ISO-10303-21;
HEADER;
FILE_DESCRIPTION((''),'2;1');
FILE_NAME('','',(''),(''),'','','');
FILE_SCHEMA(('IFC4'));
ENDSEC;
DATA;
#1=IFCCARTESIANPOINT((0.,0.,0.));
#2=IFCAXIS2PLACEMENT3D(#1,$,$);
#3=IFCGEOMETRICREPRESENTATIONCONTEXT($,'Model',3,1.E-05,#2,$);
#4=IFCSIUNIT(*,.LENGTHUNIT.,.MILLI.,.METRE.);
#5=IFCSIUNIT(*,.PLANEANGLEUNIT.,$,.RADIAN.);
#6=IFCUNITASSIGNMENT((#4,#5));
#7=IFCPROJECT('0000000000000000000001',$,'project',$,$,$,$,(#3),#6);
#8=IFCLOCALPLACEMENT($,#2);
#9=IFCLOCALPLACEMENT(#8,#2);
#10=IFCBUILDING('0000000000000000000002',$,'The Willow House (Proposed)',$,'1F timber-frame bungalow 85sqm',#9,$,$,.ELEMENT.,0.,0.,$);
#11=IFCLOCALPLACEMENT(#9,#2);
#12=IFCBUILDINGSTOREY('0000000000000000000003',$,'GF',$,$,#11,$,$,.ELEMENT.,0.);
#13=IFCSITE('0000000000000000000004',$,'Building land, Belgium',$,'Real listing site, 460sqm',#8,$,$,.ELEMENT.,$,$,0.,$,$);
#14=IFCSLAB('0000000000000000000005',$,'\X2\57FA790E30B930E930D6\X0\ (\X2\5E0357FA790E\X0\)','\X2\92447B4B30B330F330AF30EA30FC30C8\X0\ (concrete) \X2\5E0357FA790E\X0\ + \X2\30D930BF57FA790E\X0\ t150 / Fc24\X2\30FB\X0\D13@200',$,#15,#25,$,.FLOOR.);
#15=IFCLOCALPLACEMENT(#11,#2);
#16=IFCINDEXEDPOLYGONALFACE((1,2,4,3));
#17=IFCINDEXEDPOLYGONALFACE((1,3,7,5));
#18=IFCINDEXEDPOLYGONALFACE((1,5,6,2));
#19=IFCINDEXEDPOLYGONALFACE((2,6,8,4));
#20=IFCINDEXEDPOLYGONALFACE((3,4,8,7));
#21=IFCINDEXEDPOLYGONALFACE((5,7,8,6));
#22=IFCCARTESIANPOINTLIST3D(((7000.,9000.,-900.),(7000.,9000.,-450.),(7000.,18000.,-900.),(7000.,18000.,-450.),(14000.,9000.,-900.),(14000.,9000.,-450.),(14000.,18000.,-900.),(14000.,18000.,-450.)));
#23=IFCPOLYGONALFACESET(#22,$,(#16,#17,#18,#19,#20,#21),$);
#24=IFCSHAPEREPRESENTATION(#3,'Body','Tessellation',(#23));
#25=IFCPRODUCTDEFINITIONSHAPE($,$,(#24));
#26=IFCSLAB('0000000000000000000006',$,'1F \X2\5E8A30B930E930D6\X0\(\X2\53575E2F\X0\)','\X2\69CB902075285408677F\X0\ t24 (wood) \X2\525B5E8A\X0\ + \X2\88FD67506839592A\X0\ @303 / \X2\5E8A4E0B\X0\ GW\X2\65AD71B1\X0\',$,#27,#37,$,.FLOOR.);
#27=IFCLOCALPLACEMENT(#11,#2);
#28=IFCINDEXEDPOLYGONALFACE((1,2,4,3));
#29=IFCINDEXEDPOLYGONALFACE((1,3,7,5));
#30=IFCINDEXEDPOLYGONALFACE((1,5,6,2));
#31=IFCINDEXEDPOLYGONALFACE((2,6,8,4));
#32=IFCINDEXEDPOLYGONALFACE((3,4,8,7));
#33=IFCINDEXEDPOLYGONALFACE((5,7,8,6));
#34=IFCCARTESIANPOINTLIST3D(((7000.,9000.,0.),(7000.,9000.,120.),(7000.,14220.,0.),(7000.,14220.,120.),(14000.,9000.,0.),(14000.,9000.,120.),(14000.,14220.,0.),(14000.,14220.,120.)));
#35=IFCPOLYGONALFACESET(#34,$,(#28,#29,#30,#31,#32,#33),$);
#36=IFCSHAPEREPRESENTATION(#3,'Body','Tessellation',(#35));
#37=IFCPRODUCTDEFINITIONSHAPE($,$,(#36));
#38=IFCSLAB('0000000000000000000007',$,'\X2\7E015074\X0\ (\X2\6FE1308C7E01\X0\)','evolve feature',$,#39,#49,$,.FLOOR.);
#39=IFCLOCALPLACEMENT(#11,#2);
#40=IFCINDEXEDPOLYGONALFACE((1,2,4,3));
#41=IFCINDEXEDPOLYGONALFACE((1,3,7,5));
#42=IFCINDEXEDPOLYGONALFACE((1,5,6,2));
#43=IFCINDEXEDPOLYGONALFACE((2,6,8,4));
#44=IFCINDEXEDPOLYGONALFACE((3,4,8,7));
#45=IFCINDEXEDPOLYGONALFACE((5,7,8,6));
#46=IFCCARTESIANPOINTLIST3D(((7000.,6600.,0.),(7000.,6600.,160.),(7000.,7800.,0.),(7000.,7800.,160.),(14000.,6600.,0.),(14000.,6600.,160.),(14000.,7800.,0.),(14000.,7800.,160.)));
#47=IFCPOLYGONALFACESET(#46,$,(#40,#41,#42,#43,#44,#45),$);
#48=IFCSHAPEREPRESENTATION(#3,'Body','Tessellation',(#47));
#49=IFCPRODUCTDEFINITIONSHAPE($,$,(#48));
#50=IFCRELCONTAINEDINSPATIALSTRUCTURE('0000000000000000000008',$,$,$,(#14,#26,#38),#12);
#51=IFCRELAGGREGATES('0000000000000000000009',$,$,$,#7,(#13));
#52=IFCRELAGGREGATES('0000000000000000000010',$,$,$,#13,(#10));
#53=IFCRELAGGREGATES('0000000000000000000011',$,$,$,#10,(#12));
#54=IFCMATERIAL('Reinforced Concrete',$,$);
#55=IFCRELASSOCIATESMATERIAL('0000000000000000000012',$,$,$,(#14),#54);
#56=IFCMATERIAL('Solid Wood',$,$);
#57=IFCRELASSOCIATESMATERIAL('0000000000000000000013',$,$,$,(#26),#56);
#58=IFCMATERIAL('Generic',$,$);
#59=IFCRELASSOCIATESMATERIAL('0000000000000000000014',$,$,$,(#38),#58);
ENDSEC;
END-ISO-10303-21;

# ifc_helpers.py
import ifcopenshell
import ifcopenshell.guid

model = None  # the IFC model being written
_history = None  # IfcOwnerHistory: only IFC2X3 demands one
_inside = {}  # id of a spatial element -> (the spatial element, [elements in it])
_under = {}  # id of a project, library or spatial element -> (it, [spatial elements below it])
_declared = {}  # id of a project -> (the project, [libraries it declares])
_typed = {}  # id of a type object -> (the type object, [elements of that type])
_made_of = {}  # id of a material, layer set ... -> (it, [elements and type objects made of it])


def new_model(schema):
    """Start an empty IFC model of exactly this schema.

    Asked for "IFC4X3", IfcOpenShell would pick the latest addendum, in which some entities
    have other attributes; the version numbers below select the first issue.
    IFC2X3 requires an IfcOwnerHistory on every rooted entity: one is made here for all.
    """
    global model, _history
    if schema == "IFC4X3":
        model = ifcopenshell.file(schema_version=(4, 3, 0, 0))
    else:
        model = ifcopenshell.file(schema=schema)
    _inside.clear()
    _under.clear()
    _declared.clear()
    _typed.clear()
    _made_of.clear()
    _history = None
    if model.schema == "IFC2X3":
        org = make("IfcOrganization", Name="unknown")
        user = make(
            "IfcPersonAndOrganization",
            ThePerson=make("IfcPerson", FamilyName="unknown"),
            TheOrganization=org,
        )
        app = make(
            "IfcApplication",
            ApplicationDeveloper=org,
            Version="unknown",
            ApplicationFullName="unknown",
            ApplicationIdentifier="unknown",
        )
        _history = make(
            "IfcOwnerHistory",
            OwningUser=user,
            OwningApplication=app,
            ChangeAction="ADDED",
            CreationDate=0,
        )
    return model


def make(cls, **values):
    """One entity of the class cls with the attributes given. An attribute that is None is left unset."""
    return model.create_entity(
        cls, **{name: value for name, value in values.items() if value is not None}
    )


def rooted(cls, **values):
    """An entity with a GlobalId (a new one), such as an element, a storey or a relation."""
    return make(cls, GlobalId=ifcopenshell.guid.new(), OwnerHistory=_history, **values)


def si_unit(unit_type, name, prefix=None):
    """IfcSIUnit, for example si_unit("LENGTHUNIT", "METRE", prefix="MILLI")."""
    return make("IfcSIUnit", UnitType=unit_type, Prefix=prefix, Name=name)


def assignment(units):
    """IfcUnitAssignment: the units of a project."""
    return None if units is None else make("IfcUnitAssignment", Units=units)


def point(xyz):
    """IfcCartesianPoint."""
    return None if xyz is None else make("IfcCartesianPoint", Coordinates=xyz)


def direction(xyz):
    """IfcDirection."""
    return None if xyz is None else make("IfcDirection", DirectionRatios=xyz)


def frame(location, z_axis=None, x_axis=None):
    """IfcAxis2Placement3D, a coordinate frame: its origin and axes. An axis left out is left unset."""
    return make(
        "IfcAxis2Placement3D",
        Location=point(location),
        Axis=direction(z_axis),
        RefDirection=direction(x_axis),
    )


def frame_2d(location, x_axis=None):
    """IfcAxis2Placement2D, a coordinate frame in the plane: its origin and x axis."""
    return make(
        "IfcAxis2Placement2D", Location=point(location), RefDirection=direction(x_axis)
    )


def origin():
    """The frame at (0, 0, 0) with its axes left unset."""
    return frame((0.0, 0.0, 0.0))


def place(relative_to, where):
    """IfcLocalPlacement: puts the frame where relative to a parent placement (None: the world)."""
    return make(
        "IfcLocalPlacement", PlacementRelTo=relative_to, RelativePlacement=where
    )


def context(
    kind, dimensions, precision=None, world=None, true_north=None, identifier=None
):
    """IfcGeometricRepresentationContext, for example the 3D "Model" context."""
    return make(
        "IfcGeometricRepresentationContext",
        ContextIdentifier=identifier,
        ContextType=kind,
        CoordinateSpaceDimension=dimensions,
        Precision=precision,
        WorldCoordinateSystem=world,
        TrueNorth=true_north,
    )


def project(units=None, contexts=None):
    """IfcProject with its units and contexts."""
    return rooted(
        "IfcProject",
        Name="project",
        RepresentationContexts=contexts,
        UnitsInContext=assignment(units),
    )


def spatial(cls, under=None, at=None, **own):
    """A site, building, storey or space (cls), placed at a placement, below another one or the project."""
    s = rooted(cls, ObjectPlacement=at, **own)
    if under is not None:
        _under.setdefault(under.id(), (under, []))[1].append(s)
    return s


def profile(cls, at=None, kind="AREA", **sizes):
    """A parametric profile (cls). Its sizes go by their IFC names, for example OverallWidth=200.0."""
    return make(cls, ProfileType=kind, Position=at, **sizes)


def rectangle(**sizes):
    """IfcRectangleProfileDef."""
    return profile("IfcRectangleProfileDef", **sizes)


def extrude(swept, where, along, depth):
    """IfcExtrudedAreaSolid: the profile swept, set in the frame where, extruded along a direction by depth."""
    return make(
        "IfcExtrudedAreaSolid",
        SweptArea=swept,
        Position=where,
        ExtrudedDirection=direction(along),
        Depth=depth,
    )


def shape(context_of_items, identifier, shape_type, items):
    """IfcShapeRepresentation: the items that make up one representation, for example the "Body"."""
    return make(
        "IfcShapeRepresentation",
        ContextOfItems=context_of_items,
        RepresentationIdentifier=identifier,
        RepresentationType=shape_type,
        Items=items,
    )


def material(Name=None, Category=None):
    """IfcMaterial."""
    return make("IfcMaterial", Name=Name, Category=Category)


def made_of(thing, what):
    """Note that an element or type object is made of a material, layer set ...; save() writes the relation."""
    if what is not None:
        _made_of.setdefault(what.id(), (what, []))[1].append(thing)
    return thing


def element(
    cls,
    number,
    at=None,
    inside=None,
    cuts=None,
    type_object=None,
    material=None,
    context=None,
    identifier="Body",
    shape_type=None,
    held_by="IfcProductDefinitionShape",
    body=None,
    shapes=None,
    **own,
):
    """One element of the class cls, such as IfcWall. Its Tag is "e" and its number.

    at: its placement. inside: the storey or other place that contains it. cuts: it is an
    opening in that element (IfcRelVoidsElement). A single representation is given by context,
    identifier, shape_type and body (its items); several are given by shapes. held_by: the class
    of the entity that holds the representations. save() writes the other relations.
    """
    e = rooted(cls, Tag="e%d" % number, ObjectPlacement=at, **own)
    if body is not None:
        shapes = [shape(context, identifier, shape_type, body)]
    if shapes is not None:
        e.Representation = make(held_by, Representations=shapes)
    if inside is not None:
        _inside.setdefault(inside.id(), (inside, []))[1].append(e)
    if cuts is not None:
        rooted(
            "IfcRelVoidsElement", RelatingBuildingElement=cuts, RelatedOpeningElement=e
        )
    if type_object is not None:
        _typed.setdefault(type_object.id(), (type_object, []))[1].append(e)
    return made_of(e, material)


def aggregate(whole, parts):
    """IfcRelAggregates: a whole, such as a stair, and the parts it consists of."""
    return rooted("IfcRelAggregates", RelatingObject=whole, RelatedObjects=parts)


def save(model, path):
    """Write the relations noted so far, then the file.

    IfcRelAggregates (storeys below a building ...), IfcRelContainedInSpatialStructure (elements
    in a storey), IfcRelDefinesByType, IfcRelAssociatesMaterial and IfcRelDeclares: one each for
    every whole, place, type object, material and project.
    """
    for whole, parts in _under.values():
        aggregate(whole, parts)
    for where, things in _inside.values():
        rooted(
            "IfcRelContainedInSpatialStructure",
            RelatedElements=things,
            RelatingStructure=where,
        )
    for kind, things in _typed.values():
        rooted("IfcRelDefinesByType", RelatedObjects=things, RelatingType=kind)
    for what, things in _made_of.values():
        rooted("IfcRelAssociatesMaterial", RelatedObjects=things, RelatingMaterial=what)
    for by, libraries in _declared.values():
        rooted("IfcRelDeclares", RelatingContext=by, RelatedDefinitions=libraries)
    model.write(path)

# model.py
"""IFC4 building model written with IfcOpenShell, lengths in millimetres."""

from ifc_helpers import new_model, si_unit, frame, frame_2d, origin, place, context, project, spatial, rectangle, extrude, material, element, save


model = new_model("IFC4")

# Units and contexts
model_context = context("Model", 3, precision=1e-05, world=origin())
ifc_project = project(units=[si_unit("LENGTHUNIT", "METRE", prefix="MILLI"), si_unit("PLANEANGLEUNIT", "RADIAN")], contexts=[model_context])

# Site, building, storey
site_placement = place(None, origin())
site = spatial("IfcSite", under=ifc_project, at=site_placement, Name="Building land, Belgium", ObjectType="Real listing site, 460sqm", CompositionType="ELEMENT", RefElevation=0.0)
building_placement = place(site_placement, origin())
building = spatial("IfcBuilding", under=site, at=building_placement, Name="The Willow House (Proposed)", ObjectType="1F timber-frame bungalow 85sqm", CompositionType="ELEMENT", ElevationOfRefHeight=0.0, ElevationOfTerrain=0.0)
storey_placement = place(building_placement, origin())
storey = spatial("IfcBuildingStorey", under=building, at=storey_placement, Name="GF", CompositionType="ELEMENT", Elevation=0.0)

# Slabs
ifc_material_1 = material(Name="Reinforced Concrete")
slab_1_placement = place(storey_placement, frame((3500.0, 4500.0, -450.0)))
element("IfcSlab", 1, at=slab_1_placement, inside=storey, material=ifc_material_1, Name="基礎スラブ (布基礎)", Description="鉄筋コンクリート (concrete) 布基礎 + ベタ基礎 t150 / Fc24・D13@200", PredefinedType="FLOOR", context=model_context, shape_type="SweptSolid", body=[
    extrude(rectangle(XDim=7000.0, YDim=9000.0, at=frame_2d((3500.0, 4500.0))), frame((3500.0, 4500.0, -450.0)), (0.0, 0.0, 1.0), 450.0),
])
ifc_material_2 = material(Name="Solid Wood")
slab_2_placement = place(storey_placement, frame((3500.0, 4500.0, 0.0)))
element("IfcSlab", 2, at=slab_2_placement, inside=storey, material=ifc_material_2, Name="1F 床スラブ(南帯)", Description="構造用合板 t24 (wood) 剛床 + 製材根太 @303 / 床下 GW断熱", PredefinedType="FLOOR", context=model_context, shape_type="SweptSolid", body=[
    extrude(rectangle(XDim=7000.0, YDim=5220.0, at=frame_2d((3500.0, 2610.0))), frame((3500.0, 4500.0, 0.0)), (0.0, 0.0, 1.0), 120.0),
])
ifc_material_3 = material(Name="Generic")
slab_3_placement = place(storey_placement, frame((3500.0, 3300.0, 0.0)))
element("IfcSlab", 3, at=slab_3_placement, inside=storey, material=ifc_material_3, Name="縁側 (濡れ縁)", Description="evolve feature", PredefinedType="FLOOR", context=model_context, shape_type="SweptSolid", body=[
    extrude(rectangle(XDim=7000.0, YDim=1200.0, at=frame_2d((3500.0, 600.0))), frame((3500.0, 3300.0, 0.0)), (0.0, 0.0, 1.0), 160.0),
])

save(model, "model.ifc")
